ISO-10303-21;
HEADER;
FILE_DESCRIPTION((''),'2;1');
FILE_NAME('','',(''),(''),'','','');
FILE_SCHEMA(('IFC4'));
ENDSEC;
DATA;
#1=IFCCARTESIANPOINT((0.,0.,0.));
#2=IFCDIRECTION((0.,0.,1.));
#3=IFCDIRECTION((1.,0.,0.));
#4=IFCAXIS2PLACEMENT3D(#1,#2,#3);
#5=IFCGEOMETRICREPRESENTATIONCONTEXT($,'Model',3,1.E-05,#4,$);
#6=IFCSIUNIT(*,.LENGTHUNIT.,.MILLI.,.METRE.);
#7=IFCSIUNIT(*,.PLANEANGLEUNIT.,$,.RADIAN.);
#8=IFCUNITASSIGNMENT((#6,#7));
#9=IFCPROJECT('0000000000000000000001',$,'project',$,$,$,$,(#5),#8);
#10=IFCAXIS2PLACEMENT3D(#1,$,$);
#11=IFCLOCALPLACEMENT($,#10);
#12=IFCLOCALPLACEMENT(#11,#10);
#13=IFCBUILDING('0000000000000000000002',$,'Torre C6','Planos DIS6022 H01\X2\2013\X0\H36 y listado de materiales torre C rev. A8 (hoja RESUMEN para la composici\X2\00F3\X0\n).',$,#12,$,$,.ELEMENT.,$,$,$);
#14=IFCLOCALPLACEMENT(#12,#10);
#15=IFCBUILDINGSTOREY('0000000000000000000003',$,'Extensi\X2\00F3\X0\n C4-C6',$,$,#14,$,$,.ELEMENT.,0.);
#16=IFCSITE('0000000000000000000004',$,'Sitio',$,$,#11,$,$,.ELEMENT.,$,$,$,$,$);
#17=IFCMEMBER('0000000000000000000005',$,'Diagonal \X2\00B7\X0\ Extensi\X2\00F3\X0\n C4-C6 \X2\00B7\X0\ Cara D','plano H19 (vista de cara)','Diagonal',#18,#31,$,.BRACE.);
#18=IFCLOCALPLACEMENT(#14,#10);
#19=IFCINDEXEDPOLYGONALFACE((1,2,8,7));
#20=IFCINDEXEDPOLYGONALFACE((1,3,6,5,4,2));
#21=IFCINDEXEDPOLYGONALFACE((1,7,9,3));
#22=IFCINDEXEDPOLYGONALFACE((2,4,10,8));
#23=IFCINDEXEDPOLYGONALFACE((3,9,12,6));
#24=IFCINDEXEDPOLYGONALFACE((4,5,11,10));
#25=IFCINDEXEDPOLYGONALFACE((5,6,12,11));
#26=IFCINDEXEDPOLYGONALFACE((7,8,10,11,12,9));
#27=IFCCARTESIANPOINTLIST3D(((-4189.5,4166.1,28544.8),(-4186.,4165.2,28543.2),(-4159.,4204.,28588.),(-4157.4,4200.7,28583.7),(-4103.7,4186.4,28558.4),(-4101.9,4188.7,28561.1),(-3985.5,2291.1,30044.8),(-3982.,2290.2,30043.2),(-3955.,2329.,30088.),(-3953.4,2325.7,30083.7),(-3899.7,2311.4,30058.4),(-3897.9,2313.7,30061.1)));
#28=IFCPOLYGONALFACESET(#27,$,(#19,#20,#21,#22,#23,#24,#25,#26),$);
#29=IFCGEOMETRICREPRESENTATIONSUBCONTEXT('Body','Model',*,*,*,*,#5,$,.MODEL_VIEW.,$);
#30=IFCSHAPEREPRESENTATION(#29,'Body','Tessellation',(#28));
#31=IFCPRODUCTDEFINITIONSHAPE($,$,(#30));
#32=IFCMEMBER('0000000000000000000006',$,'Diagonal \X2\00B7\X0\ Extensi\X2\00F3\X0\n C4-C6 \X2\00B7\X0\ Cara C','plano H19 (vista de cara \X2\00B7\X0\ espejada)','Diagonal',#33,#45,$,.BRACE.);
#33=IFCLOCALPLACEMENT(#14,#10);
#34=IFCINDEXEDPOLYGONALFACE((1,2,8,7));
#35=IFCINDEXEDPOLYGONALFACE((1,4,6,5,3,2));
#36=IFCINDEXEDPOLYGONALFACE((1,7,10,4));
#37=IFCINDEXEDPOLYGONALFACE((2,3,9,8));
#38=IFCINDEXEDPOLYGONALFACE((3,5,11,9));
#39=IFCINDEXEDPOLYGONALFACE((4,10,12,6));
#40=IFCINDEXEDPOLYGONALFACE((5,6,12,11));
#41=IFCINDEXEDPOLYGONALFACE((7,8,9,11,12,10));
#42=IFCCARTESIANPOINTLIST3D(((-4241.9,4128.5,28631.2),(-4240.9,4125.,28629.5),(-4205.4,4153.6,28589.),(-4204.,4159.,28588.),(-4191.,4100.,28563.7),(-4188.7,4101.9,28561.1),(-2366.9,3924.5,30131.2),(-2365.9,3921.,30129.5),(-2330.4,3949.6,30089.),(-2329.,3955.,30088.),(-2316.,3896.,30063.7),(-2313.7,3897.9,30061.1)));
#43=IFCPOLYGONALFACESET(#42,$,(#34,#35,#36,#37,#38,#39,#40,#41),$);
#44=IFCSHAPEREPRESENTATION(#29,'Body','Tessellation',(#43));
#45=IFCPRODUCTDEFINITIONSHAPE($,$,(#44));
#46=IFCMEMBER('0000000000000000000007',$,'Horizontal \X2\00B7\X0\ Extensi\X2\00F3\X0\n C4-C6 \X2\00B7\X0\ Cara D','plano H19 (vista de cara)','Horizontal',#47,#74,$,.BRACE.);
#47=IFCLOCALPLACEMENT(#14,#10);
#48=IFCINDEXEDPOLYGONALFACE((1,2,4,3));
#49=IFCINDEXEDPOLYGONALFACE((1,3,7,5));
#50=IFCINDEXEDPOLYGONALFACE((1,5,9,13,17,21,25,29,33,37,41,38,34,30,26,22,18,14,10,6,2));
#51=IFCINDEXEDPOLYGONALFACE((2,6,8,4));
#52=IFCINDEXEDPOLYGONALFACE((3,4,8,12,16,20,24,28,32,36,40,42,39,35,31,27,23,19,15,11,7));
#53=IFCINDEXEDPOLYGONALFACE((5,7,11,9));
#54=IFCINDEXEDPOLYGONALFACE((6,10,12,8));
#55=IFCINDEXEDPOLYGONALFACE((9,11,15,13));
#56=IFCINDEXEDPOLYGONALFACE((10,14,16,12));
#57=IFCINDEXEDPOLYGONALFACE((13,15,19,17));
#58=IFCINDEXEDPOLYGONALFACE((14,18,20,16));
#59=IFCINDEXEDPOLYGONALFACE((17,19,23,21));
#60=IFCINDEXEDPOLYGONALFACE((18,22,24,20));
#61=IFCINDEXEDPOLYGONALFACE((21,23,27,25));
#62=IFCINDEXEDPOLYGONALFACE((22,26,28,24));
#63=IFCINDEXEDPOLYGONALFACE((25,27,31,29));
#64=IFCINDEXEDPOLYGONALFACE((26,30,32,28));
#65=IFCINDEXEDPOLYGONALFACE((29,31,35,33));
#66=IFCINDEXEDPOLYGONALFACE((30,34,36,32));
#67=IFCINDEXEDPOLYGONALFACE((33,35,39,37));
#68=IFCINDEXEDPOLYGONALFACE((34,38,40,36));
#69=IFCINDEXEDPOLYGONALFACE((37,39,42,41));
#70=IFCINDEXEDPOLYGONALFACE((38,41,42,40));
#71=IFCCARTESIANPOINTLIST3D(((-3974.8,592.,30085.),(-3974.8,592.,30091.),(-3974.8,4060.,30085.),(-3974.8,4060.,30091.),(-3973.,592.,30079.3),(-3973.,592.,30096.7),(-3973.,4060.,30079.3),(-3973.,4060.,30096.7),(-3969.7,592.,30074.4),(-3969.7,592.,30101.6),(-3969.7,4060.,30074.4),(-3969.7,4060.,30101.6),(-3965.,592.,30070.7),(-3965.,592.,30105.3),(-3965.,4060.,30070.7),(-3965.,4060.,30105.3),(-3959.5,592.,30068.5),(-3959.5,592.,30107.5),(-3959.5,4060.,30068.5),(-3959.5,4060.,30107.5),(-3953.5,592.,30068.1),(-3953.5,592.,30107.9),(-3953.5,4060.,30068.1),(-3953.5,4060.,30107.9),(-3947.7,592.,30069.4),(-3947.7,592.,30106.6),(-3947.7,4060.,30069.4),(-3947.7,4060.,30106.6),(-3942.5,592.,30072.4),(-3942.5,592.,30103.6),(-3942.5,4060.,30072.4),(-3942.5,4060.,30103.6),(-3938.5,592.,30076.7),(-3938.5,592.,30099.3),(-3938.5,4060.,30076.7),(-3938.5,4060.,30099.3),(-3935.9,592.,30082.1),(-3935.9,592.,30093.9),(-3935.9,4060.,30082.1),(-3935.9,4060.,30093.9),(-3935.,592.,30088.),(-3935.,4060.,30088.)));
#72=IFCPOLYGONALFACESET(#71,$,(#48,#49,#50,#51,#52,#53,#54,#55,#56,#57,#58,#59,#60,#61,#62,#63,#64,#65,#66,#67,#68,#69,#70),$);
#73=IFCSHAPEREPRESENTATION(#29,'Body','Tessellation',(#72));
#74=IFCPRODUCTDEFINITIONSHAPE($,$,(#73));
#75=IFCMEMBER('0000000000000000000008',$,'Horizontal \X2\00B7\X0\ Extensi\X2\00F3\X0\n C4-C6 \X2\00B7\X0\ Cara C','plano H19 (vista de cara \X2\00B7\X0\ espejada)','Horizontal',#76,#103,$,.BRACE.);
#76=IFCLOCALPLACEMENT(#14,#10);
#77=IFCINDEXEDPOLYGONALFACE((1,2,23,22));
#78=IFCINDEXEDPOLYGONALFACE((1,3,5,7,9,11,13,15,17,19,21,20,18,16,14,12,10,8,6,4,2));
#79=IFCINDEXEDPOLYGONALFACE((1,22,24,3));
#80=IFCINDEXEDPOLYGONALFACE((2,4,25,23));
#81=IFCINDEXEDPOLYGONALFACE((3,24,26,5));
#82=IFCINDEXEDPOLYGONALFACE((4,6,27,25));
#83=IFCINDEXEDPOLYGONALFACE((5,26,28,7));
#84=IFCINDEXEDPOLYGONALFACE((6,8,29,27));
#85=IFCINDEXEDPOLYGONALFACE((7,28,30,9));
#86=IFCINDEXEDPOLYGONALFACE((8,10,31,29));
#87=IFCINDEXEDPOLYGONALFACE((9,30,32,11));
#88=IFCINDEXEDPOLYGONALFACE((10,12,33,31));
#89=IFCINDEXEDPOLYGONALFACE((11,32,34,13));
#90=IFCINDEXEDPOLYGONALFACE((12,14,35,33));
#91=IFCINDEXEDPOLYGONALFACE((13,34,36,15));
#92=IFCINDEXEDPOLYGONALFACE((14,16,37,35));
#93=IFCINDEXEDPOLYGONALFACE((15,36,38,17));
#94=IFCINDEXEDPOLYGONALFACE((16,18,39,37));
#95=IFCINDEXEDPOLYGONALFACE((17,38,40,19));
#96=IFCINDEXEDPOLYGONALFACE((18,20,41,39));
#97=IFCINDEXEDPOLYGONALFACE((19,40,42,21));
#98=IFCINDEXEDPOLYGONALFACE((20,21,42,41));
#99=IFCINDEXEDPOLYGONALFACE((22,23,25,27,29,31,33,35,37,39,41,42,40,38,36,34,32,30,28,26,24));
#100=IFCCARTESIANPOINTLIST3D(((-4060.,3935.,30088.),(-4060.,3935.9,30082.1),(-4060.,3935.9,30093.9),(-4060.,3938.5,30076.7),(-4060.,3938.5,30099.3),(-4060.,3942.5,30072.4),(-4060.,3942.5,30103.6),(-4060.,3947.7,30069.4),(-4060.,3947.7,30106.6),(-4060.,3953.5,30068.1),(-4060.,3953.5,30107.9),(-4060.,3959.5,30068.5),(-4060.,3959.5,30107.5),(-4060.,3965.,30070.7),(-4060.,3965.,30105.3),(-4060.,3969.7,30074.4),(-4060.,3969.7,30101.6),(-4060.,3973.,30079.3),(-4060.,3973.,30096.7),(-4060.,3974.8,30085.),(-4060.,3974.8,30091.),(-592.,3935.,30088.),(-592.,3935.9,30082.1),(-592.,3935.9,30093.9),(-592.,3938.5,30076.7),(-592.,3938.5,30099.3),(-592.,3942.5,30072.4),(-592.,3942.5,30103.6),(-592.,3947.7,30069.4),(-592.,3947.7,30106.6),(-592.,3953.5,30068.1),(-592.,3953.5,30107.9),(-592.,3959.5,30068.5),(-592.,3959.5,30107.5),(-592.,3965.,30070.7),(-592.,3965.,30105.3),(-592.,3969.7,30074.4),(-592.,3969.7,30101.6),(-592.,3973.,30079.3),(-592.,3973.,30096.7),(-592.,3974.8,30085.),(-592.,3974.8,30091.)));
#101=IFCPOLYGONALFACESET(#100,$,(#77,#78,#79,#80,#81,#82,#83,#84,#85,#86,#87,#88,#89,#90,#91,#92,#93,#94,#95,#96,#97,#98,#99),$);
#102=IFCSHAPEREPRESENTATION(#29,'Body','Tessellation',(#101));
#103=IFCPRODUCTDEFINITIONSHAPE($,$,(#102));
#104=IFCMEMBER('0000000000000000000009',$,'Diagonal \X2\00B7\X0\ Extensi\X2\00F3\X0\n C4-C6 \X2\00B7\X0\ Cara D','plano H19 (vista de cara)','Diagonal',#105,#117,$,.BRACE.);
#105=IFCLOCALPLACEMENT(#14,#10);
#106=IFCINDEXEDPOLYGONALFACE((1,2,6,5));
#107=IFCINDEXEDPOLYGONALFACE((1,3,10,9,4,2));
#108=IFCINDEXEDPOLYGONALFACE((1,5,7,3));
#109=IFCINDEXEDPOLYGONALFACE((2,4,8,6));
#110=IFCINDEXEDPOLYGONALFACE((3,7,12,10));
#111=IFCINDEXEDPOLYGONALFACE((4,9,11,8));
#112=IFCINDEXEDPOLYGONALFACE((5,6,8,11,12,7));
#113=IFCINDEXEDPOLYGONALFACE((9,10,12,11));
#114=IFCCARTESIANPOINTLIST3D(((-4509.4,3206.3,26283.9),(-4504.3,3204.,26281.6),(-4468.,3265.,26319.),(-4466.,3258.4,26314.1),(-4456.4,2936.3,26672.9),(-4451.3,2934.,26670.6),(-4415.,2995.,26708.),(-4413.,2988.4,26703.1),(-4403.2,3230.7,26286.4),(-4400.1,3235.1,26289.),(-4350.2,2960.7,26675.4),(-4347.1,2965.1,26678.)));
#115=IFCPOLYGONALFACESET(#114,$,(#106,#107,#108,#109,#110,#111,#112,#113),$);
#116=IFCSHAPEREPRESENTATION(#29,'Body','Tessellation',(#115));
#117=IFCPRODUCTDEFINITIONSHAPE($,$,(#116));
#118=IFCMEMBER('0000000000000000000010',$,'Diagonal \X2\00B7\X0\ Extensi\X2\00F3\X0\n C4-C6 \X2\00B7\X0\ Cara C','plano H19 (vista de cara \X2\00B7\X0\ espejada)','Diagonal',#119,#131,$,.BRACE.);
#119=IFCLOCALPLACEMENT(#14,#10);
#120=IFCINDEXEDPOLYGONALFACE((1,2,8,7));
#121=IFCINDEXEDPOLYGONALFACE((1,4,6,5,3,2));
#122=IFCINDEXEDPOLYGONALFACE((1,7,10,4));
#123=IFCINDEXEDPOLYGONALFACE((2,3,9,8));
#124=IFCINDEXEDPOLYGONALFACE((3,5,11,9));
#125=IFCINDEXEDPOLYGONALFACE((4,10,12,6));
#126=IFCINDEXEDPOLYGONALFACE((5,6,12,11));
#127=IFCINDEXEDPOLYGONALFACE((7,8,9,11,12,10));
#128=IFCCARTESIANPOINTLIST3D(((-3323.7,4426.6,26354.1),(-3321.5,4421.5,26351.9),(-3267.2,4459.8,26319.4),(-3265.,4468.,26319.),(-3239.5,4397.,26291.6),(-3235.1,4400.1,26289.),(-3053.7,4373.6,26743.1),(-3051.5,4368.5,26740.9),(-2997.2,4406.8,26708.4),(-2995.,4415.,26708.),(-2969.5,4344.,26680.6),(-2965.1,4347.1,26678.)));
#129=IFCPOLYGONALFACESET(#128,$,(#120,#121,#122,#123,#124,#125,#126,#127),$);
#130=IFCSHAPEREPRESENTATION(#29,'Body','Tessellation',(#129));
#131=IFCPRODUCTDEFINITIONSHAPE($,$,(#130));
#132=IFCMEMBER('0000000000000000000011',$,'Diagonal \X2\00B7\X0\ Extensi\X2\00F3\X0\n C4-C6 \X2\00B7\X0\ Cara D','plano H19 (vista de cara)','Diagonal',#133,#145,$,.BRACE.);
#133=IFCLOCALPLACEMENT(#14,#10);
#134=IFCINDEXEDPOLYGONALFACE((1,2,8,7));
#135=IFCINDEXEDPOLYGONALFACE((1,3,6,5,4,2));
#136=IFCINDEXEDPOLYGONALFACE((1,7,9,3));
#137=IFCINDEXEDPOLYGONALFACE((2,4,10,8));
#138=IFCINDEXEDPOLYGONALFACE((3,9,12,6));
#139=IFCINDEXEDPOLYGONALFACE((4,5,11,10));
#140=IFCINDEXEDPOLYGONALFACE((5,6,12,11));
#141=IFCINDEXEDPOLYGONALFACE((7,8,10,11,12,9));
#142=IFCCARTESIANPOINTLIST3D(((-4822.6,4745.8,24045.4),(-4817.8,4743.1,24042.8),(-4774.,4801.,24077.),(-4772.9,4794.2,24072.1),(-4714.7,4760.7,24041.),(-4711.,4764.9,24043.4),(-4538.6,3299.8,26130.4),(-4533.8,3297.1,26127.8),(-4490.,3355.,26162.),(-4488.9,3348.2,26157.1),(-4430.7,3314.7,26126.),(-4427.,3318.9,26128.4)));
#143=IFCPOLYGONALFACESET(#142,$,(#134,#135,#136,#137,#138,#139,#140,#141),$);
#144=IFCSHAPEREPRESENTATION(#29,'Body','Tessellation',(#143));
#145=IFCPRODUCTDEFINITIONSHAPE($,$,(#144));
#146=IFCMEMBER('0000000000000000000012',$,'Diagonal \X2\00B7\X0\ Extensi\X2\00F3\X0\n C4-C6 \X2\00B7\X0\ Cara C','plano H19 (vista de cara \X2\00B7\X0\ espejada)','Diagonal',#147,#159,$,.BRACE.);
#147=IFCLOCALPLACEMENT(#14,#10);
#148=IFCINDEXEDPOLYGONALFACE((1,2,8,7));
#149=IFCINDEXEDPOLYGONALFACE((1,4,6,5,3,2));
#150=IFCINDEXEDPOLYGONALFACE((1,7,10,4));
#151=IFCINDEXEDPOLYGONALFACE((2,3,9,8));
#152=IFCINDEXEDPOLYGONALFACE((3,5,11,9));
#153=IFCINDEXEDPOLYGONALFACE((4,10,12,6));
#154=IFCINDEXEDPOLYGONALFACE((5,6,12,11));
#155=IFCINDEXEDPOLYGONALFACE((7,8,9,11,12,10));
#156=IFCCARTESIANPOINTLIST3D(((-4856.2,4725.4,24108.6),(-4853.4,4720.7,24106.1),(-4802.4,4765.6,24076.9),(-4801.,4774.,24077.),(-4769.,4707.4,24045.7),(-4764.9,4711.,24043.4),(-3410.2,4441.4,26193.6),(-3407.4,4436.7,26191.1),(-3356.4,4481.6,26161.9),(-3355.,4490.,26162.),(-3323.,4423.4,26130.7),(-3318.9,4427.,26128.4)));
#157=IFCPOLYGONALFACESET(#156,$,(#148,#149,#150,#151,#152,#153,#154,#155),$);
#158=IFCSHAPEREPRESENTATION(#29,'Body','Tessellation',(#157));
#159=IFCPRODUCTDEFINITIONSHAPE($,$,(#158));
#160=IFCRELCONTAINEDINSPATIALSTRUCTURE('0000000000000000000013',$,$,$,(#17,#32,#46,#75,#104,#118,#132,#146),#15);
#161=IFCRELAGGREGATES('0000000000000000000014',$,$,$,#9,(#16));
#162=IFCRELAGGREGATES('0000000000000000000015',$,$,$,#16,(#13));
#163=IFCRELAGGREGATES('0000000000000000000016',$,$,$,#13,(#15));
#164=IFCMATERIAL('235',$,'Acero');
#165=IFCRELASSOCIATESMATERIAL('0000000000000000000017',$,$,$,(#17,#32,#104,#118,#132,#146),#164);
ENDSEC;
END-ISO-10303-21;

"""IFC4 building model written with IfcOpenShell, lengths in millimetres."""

from ifc_helpers import new_model, si_unit, frame, frame_2d, origin, origin_with_axes, place, context, subcontext, project, spatial, circle, l_section, extrude, material, element, save


model = new_model("IFC4")

# Units and contexts
model_context = context("Model", 3, precision=1e-05, world=origin_with_axes())
body_context = subcontext(model_context, "Body", "Model", "MODEL_VIEW")
ifc_project = project(units=[si_unit("LENGTHUNIT", "METRE", prefix="MILLI"), si_unit("PLANEANGLEUNIT", "RADIAN")], contexts=[model_context])

# Site, building, storey
site_placement = place(None, origin())
site = spatial("IfcSite", under=ifc_project, at=site_placement, Name="Sitio", CompositionType="ELEMENT")
building_placement = place(site_placement, origin())
building = spatial("IfcBuilding", under=site, at=building_placement, Name="Torre C6", Description="Planos DIS6022 H01–H36 y listado de materiales torre C rev. A8 (hoja RESUMEN para la composición).", CompositionType="ELEMENT")
storey_placement = place(building_placement, origin())
storey = spatial("IfcBuildingStorey", under=building, at=storey_placement, Name="Extensión C4-C6", CompositionType="ELEMENT", Elevation=0.0)

# Members
ifc_material = material(Name="235", Category="Acero")
for number, where, z_axis, x_axis, name, description in (
    (1, (-3955.0, 2329.0, 30088.0), (-0.084654, 0.778066, -0.622453), (0.879209, -0.235619, -0.414097), "Diagonal · Extensión C4-C6 · Cara D", "plano H19 (vista de cara)"),
    (2, (-2329.0, 3955.0, 30088.0), (-0.778066, 0.084654, -0.622453), (0.235619, -0.879209, -0.414097), "Diagonal · Extensión C4-C6 · Cara C", "plano H19 (vista de cara · espejada)"),
):
    element("IfcMember", number, at=place(storey_placement, frame(where, z_axis=z_axis, x_axis=x_axis)), inside=storey, material=ifc_material, Name=name, Description=description, ObjectType="Diagonal", PredefinedType="BRACE", context=body_context, shape_type="SweptSolid", body=[
        extrude(l_section(Depth=65.0, Width=65.0, Thickness=4.0, at=frame_2d((32.5, 32.5))), None, (0.0, 0.0, 1.0), 2409.8),
    ])
for number, where, z_axis, x_axis, name, description in (
    (3, (-3955.0, 592.0, 30088.0), (0.0, 1.0, 0.0), (1.0, 0.0, 0.0), "Horizontal · Extensión C4-C6 · Cara D", "plano H19 (vista de cara)"),
    (4, (-592.0, 3955.0, 30088.0), (-1.0, 0.0, 0.0), (0.0, -1.0, 0.0), "Horizontal · Extensión C4-C6 · Cara C", "plano H19 (vista de cara · espejada)"),
):
    element("IfcMember", number, at=place(storey_placement, frame(where, z_axis=z_axis, x_axis=x_axis)), inside=storey, Name=name, Description=description, ObjectType="Horizontal", PredefinedType="BRACE", context=body_context, shape_type="SweptSolid", body=[
        extrude(circle(Radius=20.0), None, (0.0, 0.0, 1.0), 3468.0),
    ])
for number, where, z_axis, x_axis, name, description in (
    (5, (-4415.0, 2995.0, 26708.0), (-0.111233, 0.566659, -0.816409), (0.848414, -0.37365, -0.37494), "Diagonal · Extensión C4-C6 · Cara D", "plano H19 (vista de cara)"),
    (6, (-2995.0, 4415.0, 26708.0), (-0.566659, 0.111233, -0.816409), (0.37365, -0.848414, -0.37494), "Diagonal · Extensión C4-C6 · Cara C", "plano H19 (vista de cara · espejada)"),
):
    element("IfcMember", number, at=place(storey_placement, frame(where, z_axis=z_axis, x_axis=x_axis)), inside=storey, material=ifc_material, Name=name, Description=description, ObjectType="Diagonal", PredefinedType="BRACE", context=body_context, shape_type="SweptSolid", body=[
        extrude(l_section(Depth=80.0, Width=80.0, Thickness=6.0, at=frame_2d((40.0, 40.0))), None, (0.0, 0.0, 1.0), 476.5),
    ])
for number, where, z_axis, x_axis, name, description in (
    (7, (-4490.0, 3355.0, 26162.0), (-0.111233, 0.56635, -0.816624), (0.786928, -0.451653, -0.420421), "Diagonal · Extensión C4-C6 · Cara D", "plano H19 (vista de cara)"),
    (8, (-3355.0, 4490.0, 26162.0), (-0.56635, 0.111233, -0.816624), (0.451653, -0.786928, -0.420421), "Diagonal · Extensión C4-C6 · Cara C", "plano H19 (vista de cara · espejada)"),
):
    element("IfcMember", number, at=place(storey_placement, frame(where, z_axis=z_axis, x_axis=x_axis)), inside=storey, material=ifc_material, Name=name, Description=description, ObjectType="Diagonal", PredefinedType="BRACE", context=body_context, shape_type="SweptSolid", body=[
        extrude(l_section(Depth=80.0, Width=80.0, Thickness=6.0, at=frame_2d((40.0, 40.0))), None, (0.0, 0.0, 1.0), 2553.2),
    ])

save(model, "model.ifc")
